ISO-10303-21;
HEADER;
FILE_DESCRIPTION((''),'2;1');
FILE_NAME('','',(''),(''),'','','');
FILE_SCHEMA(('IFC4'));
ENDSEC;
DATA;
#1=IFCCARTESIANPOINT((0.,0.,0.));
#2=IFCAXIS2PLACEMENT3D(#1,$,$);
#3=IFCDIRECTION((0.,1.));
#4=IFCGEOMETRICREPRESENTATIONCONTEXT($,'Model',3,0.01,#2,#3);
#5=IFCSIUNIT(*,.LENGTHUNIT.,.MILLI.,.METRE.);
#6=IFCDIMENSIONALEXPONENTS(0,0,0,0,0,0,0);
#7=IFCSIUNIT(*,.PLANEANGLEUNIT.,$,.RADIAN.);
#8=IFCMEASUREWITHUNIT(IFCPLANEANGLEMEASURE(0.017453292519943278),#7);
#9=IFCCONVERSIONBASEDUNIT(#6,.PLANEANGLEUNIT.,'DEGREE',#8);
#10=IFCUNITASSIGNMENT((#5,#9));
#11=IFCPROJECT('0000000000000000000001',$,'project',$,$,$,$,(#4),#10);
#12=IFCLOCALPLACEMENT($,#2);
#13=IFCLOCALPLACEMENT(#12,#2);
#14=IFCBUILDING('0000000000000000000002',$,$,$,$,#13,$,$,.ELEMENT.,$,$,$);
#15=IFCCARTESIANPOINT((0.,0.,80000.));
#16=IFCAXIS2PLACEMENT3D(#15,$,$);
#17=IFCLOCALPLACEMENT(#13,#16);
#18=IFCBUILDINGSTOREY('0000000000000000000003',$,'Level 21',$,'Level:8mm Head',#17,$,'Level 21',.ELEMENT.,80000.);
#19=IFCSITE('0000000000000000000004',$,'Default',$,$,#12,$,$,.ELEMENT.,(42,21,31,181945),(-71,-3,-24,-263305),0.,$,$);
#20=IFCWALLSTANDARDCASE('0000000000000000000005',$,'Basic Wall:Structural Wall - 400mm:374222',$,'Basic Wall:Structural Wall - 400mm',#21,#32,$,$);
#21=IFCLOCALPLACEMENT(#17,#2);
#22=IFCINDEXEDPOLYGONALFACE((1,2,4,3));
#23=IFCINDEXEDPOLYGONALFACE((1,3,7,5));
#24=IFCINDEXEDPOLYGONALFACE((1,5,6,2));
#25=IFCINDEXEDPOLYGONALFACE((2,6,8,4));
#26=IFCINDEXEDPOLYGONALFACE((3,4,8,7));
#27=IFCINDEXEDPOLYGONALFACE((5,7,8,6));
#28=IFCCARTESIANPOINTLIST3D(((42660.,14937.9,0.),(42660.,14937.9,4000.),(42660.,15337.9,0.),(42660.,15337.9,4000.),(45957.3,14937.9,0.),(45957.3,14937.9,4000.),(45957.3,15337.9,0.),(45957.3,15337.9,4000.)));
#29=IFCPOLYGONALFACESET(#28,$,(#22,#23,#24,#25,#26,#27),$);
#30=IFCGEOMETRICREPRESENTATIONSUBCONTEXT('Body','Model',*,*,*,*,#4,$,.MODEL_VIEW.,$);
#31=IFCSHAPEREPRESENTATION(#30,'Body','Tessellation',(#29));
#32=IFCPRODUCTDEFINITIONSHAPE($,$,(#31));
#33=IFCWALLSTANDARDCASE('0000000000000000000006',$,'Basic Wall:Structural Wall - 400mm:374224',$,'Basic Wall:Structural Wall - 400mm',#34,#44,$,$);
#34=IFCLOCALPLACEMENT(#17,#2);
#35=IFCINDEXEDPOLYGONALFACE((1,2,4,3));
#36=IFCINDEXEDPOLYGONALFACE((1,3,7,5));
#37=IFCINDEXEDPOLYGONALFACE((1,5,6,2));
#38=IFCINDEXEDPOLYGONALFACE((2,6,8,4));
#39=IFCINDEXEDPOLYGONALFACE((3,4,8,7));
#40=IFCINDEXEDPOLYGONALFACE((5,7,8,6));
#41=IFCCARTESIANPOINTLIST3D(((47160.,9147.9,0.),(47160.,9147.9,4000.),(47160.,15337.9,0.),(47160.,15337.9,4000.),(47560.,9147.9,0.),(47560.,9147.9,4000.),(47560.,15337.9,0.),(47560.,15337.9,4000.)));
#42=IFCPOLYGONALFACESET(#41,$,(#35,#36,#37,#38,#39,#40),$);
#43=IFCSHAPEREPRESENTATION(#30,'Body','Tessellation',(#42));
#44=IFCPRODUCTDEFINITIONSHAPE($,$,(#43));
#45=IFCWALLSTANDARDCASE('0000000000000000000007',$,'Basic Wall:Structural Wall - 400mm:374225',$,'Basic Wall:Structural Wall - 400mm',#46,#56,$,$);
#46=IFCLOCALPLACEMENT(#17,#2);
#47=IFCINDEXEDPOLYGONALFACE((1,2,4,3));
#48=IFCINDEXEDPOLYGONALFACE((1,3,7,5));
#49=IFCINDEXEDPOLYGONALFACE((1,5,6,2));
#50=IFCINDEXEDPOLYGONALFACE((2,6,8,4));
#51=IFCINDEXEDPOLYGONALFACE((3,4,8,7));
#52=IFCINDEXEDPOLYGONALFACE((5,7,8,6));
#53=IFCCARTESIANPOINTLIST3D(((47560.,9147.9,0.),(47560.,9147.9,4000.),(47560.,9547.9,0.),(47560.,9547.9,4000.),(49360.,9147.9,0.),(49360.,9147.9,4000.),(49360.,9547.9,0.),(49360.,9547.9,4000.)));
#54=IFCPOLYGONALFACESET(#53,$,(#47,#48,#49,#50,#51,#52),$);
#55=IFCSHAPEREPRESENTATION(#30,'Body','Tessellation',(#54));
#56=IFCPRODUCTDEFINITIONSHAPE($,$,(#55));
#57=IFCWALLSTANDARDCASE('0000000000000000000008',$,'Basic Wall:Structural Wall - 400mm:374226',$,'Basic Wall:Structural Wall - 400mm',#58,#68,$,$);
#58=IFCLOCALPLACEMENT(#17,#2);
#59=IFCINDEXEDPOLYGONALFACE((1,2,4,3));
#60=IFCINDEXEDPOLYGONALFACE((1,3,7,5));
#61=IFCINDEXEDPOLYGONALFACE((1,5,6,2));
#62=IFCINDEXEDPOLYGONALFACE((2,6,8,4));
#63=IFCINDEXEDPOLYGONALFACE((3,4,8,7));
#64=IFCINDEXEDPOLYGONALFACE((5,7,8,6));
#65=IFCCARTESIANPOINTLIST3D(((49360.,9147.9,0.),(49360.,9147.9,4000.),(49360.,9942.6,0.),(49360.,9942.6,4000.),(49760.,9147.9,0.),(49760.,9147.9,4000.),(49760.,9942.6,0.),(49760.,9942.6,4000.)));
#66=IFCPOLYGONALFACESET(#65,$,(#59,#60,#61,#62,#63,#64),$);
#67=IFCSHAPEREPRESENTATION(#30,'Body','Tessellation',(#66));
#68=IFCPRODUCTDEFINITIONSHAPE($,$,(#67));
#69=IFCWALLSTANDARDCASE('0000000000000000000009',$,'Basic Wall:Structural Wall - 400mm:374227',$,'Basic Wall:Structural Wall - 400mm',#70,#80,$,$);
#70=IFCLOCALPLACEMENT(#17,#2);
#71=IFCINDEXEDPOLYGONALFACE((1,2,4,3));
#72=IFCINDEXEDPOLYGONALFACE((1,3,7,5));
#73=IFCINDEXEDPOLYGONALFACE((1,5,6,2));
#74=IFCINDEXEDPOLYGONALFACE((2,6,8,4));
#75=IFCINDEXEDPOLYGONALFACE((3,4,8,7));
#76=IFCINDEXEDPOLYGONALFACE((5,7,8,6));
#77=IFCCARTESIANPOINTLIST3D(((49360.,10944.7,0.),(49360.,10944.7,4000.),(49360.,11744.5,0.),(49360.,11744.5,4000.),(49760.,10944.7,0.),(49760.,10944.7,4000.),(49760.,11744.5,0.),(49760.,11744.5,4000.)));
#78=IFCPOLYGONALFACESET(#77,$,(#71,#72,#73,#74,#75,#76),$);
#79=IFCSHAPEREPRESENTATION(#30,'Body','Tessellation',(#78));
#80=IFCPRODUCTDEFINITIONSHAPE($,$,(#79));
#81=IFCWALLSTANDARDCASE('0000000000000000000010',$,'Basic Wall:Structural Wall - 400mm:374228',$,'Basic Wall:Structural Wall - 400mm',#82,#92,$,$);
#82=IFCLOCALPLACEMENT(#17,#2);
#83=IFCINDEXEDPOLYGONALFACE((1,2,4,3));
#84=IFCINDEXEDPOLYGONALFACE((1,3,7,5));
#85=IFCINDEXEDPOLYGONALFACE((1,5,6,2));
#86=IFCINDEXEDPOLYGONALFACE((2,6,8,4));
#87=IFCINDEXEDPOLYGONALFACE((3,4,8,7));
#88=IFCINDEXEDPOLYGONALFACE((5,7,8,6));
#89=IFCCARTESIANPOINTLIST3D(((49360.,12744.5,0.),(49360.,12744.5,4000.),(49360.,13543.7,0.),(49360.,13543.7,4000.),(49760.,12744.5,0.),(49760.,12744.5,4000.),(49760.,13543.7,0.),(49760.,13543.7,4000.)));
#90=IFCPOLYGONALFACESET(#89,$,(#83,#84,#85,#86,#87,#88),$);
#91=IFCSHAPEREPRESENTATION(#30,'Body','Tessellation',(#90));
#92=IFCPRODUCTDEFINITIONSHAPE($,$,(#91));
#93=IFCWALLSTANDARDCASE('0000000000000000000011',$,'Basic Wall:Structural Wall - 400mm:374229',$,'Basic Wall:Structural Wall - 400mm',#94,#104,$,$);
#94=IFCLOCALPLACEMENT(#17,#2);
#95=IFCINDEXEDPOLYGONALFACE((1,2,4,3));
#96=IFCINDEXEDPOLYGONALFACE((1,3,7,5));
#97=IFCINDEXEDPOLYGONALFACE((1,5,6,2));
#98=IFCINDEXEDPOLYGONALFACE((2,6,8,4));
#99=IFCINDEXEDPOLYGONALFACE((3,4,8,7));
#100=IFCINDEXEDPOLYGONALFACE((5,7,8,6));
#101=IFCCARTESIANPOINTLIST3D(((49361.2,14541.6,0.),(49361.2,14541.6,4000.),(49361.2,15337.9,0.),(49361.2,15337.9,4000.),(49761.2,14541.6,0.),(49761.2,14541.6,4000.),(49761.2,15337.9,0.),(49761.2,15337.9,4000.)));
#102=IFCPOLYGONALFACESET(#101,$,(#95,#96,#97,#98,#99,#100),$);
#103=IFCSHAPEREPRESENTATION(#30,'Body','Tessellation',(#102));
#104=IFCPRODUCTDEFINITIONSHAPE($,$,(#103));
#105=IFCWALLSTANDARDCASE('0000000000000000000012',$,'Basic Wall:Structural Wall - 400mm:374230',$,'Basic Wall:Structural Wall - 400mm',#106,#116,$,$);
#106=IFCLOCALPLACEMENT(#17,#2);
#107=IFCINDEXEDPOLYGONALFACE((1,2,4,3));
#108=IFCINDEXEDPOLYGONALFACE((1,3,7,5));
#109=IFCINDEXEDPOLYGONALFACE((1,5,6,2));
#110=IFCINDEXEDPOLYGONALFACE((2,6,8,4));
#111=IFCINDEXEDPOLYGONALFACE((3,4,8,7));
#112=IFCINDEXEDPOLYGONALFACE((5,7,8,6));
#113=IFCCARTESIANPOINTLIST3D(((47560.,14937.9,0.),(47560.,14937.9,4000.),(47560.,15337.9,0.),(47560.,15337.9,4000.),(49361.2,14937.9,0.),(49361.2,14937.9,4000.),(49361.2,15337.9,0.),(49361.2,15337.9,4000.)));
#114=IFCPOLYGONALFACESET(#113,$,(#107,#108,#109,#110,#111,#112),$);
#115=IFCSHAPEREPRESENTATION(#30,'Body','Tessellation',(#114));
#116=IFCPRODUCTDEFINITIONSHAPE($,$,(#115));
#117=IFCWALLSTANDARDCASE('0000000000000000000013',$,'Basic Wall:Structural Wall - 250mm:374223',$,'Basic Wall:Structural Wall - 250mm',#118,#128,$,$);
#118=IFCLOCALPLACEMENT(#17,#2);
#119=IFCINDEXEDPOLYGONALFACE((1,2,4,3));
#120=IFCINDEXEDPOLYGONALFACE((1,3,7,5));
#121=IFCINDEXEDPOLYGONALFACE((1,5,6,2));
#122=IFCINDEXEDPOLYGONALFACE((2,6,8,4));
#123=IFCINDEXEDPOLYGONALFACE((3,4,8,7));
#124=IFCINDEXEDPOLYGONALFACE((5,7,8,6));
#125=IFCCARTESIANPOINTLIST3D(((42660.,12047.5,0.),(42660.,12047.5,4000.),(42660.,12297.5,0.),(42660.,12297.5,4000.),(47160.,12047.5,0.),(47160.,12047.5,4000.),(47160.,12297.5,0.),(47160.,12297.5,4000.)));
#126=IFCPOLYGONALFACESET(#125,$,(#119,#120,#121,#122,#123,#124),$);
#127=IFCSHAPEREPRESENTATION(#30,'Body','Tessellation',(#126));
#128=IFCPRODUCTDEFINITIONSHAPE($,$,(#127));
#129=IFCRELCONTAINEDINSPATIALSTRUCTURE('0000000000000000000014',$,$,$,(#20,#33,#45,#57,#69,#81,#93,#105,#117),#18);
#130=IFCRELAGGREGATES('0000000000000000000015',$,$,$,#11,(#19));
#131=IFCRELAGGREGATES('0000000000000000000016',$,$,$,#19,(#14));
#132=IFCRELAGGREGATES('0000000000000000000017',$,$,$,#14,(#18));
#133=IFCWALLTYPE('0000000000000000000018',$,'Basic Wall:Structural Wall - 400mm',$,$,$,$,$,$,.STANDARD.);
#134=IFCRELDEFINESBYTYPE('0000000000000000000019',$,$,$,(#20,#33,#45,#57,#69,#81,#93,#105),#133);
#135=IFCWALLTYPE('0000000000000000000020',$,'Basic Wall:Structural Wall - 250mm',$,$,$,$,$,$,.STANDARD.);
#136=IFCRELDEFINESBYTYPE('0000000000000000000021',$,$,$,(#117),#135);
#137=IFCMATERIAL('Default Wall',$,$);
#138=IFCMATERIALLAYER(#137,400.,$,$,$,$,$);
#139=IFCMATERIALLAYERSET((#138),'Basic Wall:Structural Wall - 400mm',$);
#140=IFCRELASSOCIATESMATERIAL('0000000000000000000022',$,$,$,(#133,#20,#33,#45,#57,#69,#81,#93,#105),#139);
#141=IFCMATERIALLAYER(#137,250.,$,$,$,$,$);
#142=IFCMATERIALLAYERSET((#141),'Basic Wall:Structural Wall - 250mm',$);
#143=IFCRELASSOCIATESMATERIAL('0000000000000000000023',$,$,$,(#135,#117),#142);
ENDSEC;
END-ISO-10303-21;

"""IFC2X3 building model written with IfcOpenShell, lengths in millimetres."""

from ifc_helpers import new_model, entity, si_unit, converted_unit, direction, frame, frame_2d, origin, place, context, subcontext, project, spatial, rectangle, extrude, material, layer, layer_set, layer_usage, type_object, element, save


model = new_model("IFC2X3")

# Units and contexts
model_context = context("Model", 3, precision=0.01, world=origin(), true_north=direction((0.0, 1.0)))
body_context = subcontext(model_context, "Body", "Model", "MODEL_VIEW")
ifc_project = project(units=[si_unit("LENGTHUNIT", "METRE", prefix="MILLI"), converted_unit("PLANEANGLEUNIT", "DEGREE", entity("IfcPlaneAngleMeasure", 0.017453292519943278), si_unit("PLANEANGLEUNIT", "RADIAN"), dimensions=[0, 0, 0, 0, 0, 0, 0])], contexts=[model_context])

# Site, building, storey
site_placement = place(None, origin())
site = spatial("IfcSite", under=ifc_project, at=site_placement, Name="Default", CompositionType="ELEMENT", RefLatitude=(42, 21, 31, 181945), RefLongitude=(-71, -3, -24, -263305), RefElevation=0.0)
building_placement = place(site_placement, origin())
building = spatial("IfcBuilding", under=site, at=building_placement, CompositionType="ELEMENT")
storey_placement = place(building_placement, frame((0.0, 0.0, 80000.0)))
storey = spatial("IfcBuildingStorey", under=building, at=storey_placement, Name="Level 21", ObjectType="Level:8mm Head", LongName="Level 21", CompositionType="ELEMENT", Elevation=80000.0)

# Walls
ifc_material_1 = material(Name="Default Wall")
ifc_layer_1 = layer(ifc_material_1, 400.0)
ifc_layer_set_1 = layer_set([ifc_layer_1], Name="Basic Wall:Structural Wall - 400mm")
wall_type_1 = type_object("IfcWallType", Name="Basic Wall:Structural Wall - 400mm", PredefinedType="STANDARD", material=ifc_layer_set_1)
ifc_layer_usage_1 = layer_usage(ifc_layer_set_1, "AXIS2", "POSITIVE", -200.0)
wall_1_placement = place(storey_placement, frame((45957.3, 15137.9, 0.0), z_axis=(0.0, 0.0, 1.0), x_axis=(-1.0, 0.0, 0.0)))
element("IfcWallStandardCase", 1, at=wall_1_placement, inside=storey, type_object=wall_type_1, material=ifc_layer_usage_1, Name="Basic Wall:Structural Wall - 400mm:374222", ObjectType="Basic Wall:Structural Wall - 400mm", context=body_context, shape_type="SweptSolid", body=[
    extrude(rectangle(XDim=3297.3, YDim=400.0, at=frame_2d((1648.6, 0.0), x_axis=(-1.0, 0.0))), origin(), (0.0, 0.0, 1.0), 4000.0),
])
ifc_layer_usage_2 = layer_usage(ifc_layer_set_1, "AXIS2", "POSITIVE", -200.0)
wall_2_placement = place(storey_placement, frame((47360.0, 15337.9, 0.0), z_axis=(0.0, 0.0, 1.0), x_axis=(0.0, -1.0, 0.0)))
element("IfcWallStandardCase", 2, at=wall_2_placement, inside=storey, type_object=wall_type_1, material=ifc_layer_usage_2, Name="Basic Wall:Structural Wall - 400mm:374224", ObjectType="Basic Wall:Structural Wall - 400mm", context=body_context, shape_type="SweptSolid", body=[
    extrude(rectangle(XDim=6190.0, YDim=400.0, at=frame_2d((3095.0, 0.0), x_axis=(-1.0, 0.0))), origin(), (0.0, 0.0, 1.0), 4000.0),
])
ifc_layer_usage_3 = layer_usage(ifc_layer_set_1, "AXIS2", "POSITIVE", -200.0)
wall_3_placement = place(storey_placement, frame((47560.0, 9347.9, 0.0)))
element("IfcWallStandardCase", 3, at=wall_3_placement, inside=storey, type_object=wall_type_1, material=ifc_layer_usage_3, Name="Basic Wall:Structural Wall - 400mm:374225", ObjectType="Basic Wall:Structural Wall - 400mm", context=body_context, shape_type="SweptSolid", body=[
    extrude(rectangle(XDim=1800.0, YDim=400.0, at=frame_2d((900.0, 0.0), x_axis=(-1.0, 0.0))), origin(), (0.0, 0.0, 1.0), 4000.0),
])
ifc_layer_usage_4 = layer_usage(ifc_layer_set_1, "AXIS2", "NEGATIVE", 200.0)
wall_4_placement = place(storey_placement, frame((49560.0, 9147.9, 0.0), z_axis=(0.0, 0.0, 1.0), x_axis=(0.0, 1.0, 0.0)))
element("IfcWallStandardCase", 4, at=wall_4_placement, inside=storey, type_object=wall_type_1, material=ifc_layer_usage_4, Name="Basic Wall:Structural Wall - 400mm:374226", ObjectType="Basic Wall:Structural Wall - 400mm", context=body_context, shape_type="SweptSolid", body=[
    extrude(rectangle(XDim=794.7, YDim=400.0, at=frame_2d((397.3, 0.0), x_axis=(-1.0, 0.0))), origin(), (0.0, 0.0, 1.0), 4000.0),
])
ifc_layer_usage_5 = layer_usage(ifc_layer_set_1, "AXIS2", "POSITIVE", -200.0)
wall_5_placement = place(storey_placement, frame((49560.0, 10944.7, 0.0), z_axis=(0.0, 0.0, 1.0), x_axis=(0.0, 1.0, 0.0)))
element("IfcWallStandardCase", 5, at=wall_5_placement, inside=storey, type_object=wall_type_1, material=ifc_layer_usage_5, Name="Basic Wall:Structural Wall - 400mm:374227", ObjectType="Basic Wall:Structural Wall - 400mm", context=body_context, shape_type="SweptSolid", body=[
    extrude(rectangle(XDim=799.8, YDim=400.0, at=frame_2d((399.9, 0.0), x_axis=(-1.0, 0.0))), origin(), (0.0, 0.0, 1.0), 4000.0),
])
ifc_layer_usage_6 = layer_usage(ifc_layer_set_1, "AXIS2", "POSITIVE", -200.0)
wall_6_placement = place(storey_placement, frame((49560.0, 12744.5, 0.0), z_axis=(0.0, 0.0, 1.0), x_axis=(0.0, 1.0, 0.0)))
element("IfcWallStandardCase", 6, at=wall_6_placement, inside=storey, type_object=wall_type_1, material=ifc_layer_usage_6, Name="Basic Wall:Structural Wall - 400mm:374228", ObjectType="Basic Wall:Structural Wall - 400mm", context=body_context, shape_type="SweptSolid", body=[
    extrude(rectangle(XDim=799.2, YDim=400.0, at=frame_2d((399.6, 0.0), x_axis=(-1.0, 0.0))), origin(), (0.0, 0.0, 1.0), 4000.0),
])
ifc_layer_usage_7 = layer_usage(ifc_layer_set_1, "AXIS2", "POSITIVE", -200.0)
wall_7_placement = place(storey_placement, frame((49561.2, 14541.6, 0.0), z_axis=(0.0, 0.0, 1.0), x_axis=(0.0, 1.0, 0.0)))
element("IfcWallStandardCase", 7, at=wall_7_placement, inside=storey, type_object=wall_type_1, material=ifc_layer_usage_7, Name="Basic Wall:Structural Wall - 400mm:374229", ObjectType="Basic Wall:Structural Wall - 400mm", context=body_context, shape_type="SweptSolid", body=[
    extrude(rectangle(XDim=796.3, YDim=400.0, at=frame_2d((398.2, 0.0), x_axis=(-1.0, 0.0))), origin(), (0.0, 0.0, 1.0), 4000.0),
])
ifc_layer_usage_8 = layer_usage(ifc_layer_set_1, "AXIS2", "POSITIVE", -200.0)
wall_8_placement = place(storey_placement, frame((49361.2, 15137.9, 0.0), z_axis=(0.0, 0.0, 1.0), x_axis=(-1.0, 0.0, 0.0)))
element("IfcWallStandardCase", 8, at=wall_8_placement, inside=storey, type_object=wall_type_1, material=ifc_layer_usage_8, Name="Basic Wall:Structural Wall - 400mm:374230", ObjectType="Basic Wall:Structural Wall - 400mm", context=body_context, shape_type="SweptSolid", body=[
    extrude(rectangle(XDim=1801.2, YDim=400.0, at=frame_2d((900.6, 0.0), x_axis=(-1.0, 0.0))), origin(), (0.0, 0.0, 1.0), 4000.0),
])
ifc_layer_2 = layer(ifc_material_1, 250.0)
ifc_layer_set_2 = layer_set([ifc_layer_2], Name="Basic Wall:Structural Wall - 250mm")
ifc_layer_usage_9 = layer_usage(ifc_layer_set_2, "AXIS2", "NEGATIVE", 125.0)
wall_type_2 = type_object("IfcWallType", Name="Basic Wall:Structural Wall - 250mm", PredefinedType="STANDARD", material=ifc_layer_set_2)
wall_9_placement = place(storey_placement, frame((42660.0, 12172.5, 0.0)))
element("IfcWallStandardCase", 9, at=wall_9_placement, inside=storey, type_object=wall_type_2, material=ifc_layer_usage_9, Name="Basic Wall:Structural Wall - 250mm:374223", ObjectType="Basic Wall:Structural Wall - 250mm", context=body_context, shape_type="SweptSolid", body=[
    extrude(rectangle(XDim=4500.0, YDim=250.0, at=frame_2d((2250.0, 0.0), x_axis=(-1.0, 0.0))), origin(), (0.0, 0.0, 1.0), 4000.0),
])

save(model, "model.ifc")
